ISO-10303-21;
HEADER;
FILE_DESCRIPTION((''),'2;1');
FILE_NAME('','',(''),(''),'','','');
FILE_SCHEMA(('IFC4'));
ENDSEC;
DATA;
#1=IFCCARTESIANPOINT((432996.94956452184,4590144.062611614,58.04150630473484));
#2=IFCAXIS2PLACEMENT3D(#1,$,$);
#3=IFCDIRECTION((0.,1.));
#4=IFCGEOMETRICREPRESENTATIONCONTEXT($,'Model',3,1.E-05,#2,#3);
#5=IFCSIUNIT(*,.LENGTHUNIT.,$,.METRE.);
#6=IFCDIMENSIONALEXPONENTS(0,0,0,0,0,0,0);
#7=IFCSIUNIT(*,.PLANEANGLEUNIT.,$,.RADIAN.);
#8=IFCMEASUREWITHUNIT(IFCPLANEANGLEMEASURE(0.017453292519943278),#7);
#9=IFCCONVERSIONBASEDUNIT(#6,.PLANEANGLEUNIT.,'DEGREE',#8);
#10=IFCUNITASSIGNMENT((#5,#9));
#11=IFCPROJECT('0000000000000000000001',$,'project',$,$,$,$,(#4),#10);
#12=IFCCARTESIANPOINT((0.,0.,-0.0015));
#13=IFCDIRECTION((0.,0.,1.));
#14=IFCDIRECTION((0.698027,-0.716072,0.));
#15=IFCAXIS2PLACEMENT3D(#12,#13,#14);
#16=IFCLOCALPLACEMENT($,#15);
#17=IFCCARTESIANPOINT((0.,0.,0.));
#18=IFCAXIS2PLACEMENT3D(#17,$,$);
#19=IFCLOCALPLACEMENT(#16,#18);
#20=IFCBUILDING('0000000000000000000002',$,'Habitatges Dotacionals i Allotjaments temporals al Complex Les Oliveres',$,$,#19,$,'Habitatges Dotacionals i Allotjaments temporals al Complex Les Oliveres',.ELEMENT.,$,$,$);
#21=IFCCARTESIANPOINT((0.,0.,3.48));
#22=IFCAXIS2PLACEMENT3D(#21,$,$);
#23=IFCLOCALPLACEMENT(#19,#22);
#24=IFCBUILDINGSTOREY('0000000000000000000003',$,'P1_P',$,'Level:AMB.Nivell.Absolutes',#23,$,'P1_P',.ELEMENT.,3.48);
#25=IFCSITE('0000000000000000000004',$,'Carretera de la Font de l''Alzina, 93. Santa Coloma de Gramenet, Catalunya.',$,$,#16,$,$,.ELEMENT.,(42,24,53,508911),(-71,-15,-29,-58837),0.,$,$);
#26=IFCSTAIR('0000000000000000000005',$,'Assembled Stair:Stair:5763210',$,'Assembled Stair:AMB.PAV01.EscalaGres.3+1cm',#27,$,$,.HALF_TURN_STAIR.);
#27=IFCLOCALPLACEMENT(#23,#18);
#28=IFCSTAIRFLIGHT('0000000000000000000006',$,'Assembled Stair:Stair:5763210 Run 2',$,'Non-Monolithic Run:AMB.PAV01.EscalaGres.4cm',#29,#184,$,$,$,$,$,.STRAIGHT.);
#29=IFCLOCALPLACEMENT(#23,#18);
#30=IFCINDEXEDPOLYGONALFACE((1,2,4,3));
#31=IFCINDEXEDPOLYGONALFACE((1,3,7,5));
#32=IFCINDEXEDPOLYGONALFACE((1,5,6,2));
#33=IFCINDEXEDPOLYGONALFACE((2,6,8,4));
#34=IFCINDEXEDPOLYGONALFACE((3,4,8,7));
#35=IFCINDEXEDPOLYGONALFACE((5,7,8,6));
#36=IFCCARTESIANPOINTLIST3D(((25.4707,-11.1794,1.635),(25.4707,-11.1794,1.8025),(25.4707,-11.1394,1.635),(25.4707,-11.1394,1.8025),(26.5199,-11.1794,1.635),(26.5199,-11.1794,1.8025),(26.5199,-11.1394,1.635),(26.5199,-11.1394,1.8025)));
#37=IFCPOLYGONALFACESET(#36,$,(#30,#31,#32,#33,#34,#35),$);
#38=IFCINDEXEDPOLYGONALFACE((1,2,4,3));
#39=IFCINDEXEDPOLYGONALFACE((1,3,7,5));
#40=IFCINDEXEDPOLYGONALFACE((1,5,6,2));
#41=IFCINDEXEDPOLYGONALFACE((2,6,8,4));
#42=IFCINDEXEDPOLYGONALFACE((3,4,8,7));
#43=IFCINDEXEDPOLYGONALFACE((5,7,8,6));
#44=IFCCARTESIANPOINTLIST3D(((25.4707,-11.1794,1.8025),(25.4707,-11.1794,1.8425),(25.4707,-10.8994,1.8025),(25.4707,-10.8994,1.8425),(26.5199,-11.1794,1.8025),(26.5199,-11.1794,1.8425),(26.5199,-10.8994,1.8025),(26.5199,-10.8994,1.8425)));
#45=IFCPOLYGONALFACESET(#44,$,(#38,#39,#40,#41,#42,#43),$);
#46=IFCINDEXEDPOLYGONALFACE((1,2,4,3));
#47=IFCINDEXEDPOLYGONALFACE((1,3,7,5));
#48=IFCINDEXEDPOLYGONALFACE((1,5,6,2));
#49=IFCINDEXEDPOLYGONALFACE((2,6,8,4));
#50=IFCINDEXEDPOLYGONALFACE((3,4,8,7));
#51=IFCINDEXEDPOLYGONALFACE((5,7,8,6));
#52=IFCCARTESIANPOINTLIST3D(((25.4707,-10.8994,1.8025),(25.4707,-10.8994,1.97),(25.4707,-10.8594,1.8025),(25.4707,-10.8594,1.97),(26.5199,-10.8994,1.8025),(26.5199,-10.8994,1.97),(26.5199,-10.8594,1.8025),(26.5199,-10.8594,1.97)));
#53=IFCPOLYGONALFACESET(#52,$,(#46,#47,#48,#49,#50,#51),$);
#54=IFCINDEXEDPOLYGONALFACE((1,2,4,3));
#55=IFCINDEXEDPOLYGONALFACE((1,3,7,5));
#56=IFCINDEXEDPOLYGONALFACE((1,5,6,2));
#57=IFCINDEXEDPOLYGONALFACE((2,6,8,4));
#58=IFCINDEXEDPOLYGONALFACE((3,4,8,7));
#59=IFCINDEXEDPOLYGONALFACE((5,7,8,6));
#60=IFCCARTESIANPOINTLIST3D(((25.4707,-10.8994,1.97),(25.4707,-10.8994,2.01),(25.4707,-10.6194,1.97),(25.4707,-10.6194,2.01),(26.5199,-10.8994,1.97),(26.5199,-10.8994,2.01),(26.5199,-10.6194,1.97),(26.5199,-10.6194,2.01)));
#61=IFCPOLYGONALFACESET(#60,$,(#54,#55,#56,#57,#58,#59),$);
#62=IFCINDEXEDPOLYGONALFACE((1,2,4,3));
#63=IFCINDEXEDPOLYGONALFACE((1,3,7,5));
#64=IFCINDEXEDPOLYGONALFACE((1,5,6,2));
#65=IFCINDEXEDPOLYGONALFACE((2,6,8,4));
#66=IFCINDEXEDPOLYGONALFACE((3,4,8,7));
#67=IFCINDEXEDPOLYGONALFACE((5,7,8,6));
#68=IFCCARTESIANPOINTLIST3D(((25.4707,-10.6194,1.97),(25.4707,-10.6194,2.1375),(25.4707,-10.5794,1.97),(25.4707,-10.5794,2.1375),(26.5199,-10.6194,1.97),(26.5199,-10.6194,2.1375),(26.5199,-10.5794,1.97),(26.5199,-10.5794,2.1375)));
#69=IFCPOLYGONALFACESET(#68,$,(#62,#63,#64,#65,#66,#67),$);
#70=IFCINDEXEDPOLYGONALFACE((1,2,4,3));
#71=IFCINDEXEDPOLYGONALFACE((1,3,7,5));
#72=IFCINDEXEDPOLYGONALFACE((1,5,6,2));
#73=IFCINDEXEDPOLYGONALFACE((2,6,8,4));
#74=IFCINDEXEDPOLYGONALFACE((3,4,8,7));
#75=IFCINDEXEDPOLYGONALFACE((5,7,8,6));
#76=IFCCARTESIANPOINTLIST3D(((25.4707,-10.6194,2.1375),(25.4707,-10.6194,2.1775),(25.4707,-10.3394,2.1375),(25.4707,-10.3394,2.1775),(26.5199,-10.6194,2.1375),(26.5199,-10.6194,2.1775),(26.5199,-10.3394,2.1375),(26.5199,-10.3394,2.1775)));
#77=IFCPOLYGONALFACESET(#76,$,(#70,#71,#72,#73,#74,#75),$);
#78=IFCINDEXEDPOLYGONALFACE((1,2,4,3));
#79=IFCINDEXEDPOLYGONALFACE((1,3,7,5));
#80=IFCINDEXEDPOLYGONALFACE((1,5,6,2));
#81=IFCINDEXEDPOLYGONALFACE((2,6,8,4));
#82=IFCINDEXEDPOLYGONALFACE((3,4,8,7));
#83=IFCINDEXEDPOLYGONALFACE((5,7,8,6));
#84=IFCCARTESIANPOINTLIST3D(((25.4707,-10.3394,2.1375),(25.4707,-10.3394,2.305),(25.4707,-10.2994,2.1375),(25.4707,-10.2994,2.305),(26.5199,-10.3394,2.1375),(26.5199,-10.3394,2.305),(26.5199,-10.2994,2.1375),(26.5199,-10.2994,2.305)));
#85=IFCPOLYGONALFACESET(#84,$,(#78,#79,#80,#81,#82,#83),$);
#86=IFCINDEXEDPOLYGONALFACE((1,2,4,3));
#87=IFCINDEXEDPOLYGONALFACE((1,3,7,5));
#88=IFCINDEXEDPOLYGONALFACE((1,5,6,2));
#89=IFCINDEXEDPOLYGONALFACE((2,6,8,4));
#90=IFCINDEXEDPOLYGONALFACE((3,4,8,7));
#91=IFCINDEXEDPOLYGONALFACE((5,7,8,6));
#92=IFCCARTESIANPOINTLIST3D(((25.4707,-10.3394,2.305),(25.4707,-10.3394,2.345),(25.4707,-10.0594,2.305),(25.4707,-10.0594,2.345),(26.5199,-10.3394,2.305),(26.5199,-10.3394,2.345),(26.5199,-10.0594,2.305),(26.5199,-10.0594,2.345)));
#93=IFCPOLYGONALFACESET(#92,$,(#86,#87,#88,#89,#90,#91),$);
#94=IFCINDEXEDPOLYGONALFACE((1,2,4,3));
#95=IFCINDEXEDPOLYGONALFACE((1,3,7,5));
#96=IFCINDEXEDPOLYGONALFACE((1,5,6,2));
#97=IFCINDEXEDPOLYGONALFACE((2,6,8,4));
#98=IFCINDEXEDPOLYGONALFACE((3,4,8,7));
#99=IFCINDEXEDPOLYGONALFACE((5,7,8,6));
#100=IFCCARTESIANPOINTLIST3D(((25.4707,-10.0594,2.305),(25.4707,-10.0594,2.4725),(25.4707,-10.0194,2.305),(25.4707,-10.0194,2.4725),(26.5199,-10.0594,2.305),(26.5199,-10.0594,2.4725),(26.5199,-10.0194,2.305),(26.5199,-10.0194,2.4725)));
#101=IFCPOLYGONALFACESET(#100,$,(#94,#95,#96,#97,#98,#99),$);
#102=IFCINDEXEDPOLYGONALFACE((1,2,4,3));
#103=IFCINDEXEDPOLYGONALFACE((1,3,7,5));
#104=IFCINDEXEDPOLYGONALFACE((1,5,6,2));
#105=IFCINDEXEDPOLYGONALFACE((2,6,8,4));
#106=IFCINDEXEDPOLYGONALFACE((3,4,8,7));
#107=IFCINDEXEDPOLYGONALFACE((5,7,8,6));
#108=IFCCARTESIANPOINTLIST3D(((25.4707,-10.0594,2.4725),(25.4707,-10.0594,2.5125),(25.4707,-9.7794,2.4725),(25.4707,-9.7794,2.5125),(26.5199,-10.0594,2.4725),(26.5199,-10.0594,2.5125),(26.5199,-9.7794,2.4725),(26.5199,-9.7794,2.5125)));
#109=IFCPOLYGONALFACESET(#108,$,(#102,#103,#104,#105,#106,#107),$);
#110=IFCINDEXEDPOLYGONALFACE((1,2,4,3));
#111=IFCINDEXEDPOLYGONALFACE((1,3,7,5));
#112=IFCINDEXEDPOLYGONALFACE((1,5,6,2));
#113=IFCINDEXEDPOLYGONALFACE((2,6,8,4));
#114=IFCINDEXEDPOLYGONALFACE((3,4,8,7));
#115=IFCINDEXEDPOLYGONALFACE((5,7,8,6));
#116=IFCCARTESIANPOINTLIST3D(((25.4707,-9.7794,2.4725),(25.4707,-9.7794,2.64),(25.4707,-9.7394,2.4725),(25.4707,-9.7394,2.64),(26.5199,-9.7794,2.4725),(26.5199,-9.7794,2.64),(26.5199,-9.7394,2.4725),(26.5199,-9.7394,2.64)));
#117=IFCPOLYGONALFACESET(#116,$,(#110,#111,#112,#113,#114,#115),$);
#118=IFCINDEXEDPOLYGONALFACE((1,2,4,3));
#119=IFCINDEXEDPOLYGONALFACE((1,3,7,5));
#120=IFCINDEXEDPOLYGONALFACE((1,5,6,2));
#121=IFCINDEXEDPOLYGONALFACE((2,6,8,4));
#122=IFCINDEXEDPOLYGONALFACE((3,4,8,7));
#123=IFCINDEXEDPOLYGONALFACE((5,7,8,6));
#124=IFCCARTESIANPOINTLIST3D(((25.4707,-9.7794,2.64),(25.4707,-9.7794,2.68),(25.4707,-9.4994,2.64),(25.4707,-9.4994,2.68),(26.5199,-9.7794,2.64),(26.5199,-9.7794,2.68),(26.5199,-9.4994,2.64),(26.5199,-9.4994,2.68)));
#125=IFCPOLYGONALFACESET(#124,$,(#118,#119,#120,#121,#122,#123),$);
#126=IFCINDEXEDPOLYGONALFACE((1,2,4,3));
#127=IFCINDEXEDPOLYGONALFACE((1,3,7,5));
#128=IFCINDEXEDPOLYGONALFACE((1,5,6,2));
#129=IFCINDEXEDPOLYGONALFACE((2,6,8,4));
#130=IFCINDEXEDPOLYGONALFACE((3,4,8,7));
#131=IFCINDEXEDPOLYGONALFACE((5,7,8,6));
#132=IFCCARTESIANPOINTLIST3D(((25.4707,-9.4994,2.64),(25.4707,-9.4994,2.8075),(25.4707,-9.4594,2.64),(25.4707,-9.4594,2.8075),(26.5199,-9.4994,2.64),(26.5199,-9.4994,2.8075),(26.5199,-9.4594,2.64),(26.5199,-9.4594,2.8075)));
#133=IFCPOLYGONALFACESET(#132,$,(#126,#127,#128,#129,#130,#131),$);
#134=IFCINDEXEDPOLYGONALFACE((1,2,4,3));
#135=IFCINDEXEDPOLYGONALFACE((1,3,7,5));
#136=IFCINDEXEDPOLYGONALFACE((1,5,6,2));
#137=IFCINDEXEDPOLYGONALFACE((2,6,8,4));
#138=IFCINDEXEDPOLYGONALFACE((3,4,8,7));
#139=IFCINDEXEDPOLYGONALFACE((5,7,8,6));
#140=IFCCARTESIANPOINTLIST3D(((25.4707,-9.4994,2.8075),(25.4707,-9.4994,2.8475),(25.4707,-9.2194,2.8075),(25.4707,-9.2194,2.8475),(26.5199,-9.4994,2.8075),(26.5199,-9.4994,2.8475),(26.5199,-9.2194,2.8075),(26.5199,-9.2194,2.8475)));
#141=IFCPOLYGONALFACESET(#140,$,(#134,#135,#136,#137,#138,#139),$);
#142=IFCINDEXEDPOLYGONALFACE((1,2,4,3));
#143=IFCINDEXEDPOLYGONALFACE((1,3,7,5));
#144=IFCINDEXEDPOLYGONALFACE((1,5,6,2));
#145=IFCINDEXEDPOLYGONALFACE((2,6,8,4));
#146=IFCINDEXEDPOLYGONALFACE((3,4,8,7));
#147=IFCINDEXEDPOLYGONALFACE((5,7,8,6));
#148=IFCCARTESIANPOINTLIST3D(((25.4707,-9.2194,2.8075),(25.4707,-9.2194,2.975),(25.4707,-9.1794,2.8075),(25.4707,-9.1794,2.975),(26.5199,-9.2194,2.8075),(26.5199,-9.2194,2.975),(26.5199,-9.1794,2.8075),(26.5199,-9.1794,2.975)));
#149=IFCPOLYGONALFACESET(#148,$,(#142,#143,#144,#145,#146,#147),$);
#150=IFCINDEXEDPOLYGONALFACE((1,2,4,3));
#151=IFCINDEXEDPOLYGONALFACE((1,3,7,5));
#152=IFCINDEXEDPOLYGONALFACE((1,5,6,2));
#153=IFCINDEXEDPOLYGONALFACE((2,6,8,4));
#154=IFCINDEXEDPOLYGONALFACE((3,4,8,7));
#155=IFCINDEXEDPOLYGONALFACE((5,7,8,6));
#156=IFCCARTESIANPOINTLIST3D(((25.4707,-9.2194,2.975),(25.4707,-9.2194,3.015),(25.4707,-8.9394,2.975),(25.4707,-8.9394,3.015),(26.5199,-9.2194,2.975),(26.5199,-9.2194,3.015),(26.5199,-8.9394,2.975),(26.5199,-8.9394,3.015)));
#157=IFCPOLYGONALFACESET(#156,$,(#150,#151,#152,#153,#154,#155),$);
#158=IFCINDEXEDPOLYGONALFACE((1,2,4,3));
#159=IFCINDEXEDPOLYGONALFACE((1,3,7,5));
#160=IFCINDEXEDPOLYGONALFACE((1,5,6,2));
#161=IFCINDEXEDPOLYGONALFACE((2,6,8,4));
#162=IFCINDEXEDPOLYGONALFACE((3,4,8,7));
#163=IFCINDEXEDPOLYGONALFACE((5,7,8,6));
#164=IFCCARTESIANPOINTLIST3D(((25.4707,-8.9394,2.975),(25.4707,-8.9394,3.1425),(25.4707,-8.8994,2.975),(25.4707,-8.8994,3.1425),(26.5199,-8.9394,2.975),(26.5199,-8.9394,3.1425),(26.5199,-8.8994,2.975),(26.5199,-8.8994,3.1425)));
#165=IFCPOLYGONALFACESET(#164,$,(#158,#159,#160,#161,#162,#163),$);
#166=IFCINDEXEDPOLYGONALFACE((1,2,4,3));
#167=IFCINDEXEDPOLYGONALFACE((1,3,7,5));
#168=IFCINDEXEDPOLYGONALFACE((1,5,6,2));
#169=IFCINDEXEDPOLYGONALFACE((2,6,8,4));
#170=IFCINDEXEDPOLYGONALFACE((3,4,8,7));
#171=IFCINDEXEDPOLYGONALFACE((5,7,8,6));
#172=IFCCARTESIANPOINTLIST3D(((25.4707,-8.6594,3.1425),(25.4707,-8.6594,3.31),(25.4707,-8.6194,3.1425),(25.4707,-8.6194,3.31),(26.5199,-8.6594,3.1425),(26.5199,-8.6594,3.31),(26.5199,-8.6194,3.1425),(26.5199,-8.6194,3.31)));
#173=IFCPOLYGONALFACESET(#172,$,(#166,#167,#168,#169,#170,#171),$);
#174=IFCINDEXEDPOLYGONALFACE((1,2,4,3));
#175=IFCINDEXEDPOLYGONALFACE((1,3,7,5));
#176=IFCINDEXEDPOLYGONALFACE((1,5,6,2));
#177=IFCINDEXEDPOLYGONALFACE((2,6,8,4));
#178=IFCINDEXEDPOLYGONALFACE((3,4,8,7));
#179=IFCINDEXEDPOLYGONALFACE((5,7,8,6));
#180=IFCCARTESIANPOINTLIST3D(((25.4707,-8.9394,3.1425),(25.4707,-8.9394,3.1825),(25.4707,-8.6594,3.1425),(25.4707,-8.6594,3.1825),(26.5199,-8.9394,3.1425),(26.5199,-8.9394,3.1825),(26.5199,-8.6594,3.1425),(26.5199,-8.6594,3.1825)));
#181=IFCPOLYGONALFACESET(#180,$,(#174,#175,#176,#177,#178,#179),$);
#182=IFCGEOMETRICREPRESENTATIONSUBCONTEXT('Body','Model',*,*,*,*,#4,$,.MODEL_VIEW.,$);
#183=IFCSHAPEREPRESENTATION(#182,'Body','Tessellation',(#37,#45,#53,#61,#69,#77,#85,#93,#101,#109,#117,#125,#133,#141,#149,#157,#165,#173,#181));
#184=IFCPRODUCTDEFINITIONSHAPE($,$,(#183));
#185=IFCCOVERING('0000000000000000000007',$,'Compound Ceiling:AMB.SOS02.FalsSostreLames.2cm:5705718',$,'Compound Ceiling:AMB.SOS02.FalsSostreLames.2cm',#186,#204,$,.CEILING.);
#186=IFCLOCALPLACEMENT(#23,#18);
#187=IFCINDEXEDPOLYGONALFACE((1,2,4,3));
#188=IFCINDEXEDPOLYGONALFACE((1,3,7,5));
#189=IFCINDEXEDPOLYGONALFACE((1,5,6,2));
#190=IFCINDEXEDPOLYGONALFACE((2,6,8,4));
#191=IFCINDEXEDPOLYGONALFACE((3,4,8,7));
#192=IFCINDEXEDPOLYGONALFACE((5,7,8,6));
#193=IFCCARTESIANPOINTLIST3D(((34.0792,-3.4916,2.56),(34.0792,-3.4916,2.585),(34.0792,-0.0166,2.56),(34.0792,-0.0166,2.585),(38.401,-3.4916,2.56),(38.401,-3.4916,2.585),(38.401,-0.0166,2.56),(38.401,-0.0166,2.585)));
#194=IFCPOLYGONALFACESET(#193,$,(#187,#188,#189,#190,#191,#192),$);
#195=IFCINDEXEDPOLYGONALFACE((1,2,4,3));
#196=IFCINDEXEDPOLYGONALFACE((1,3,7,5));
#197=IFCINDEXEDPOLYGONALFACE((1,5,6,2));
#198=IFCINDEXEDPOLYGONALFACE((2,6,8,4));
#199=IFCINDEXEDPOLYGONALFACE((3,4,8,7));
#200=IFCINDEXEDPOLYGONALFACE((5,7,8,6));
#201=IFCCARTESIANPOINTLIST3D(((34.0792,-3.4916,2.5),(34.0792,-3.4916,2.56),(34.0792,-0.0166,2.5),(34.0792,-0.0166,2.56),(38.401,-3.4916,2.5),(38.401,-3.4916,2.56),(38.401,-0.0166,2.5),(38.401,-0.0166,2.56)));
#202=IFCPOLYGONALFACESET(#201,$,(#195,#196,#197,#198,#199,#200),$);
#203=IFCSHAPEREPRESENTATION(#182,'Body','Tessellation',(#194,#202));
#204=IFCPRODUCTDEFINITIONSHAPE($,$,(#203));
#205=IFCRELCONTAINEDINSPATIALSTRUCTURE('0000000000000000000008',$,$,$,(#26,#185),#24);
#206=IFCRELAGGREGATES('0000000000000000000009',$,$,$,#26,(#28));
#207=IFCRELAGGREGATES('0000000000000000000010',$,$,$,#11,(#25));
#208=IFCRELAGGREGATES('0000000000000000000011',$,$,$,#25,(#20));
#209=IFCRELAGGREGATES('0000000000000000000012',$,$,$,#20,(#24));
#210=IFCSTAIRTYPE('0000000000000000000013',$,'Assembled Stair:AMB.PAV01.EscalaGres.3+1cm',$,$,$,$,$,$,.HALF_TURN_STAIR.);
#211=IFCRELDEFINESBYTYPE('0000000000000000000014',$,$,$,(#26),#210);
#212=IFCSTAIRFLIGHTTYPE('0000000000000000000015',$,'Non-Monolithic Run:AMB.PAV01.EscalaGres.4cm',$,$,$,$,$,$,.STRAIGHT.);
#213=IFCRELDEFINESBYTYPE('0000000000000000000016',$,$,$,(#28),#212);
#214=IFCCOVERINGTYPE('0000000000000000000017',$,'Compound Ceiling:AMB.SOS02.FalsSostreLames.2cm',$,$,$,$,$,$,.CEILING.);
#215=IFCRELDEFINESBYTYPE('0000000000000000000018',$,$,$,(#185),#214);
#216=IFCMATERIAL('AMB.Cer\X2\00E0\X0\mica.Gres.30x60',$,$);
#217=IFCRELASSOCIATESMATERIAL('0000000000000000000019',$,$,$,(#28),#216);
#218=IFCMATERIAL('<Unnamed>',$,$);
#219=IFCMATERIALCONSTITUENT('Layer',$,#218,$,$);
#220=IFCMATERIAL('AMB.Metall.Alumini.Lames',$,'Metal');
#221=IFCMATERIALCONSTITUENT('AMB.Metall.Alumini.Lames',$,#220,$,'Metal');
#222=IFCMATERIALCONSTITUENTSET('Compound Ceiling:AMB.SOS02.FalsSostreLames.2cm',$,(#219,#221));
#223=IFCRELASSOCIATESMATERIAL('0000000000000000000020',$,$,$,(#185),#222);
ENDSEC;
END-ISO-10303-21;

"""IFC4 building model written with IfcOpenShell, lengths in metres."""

from ifc_helpers import new_model, entity, si_unit, converted_unit, direction, frame, origin, place, context, subcontext, project, spatial, indexed_curve, outline, extrude, material, constituent, constituent_set, type_object, element, aggregate, save


model = new_model("IFC4")

# Units and contexts
model_context = context("Model", 3, precision=1e-05, world=frame((432996.94956452184, 4590144.062611614, 58.04150630473484)), true_north=direction((0.0, 1.0)))
body_context = subcontext(model_context, "Body", "Model", "MODEL_VIEW")
ifc_project = project(units=[si_unit("LENGTHUNIT", "METRE"), converted_unit("PLANEANGLEUNIT", "DEGREE", entity("IfcPlaneAngleMeasure", 0.017453292519943278), si_unit("PLANEANGLEUNIT", "RADIAN"), dimensions=[0, 0, 0, 0, 0, 0, 0])], contexts=[model_context])

# Site, building, storey
site_placement = place(None, frame((0.0, 0.0, -0.0015), z_axis=(0.0, 0.0, 1.0), x_axis=(0.698027, -0.716072, 0.0)))
site = spatial("IfcSite", under=ifc_project, at=site_placement, Name="Carretera de la Font de l'Alzina, 93. Santa Coloma de Gramenet, Catalunya.", CompositionType="ELEMENT", RefLatitude=(42, 24, 53, 508911), RefLongitude=(-71, -15, -29, -58837), RefElevation=0.0)
building_placement = place(site_placement, origin())
building = spatial("IfcBuilding", under=site, at=building_placement, Name="Habitatges Dotacionals i Allotjaments temporals al Complex Les Oliveres", LongName="Habitatges Dotacionals i Allotjaments temporals al Complex Les Oliveres", CompositionType="ELEMENT")
storey_placement = place(building_placement, frame((0.0, 0.0, 3.48)))
storey = spatial("IfcBuildingStorey", under=building, at=storey_placement, Name="P1_P", ObjectType="Level:AMB.Nivell.Absolutes", LongName="P1_P", CompositionType="ELEMENT", Elevation=3.48)

# Shared definitions
ifc_material_1 = material(Name="<Unnamed>")

# Stair
stair_type_1 = type_object("IfcStairType", Name="Assembled Stair:AMB.PAV01.EscalaGres.3+1cm", PredefinedType="HALF_TURN_STAIR")
ifc_material_2 = material(Name="AMB.Ceràmica.Gres.30x60")
stair_1_placement = place(storey_placement, origin())
stair_1 = element("IfcStair", 1, at=stair_1_placement, inside=storey, type_object=stair_type_1, Name="Assembled Stair:Stair:5763210", ObjectType="Assembled Stair:AMB.PAV01.EscalaGres.3+1cm", PredefinedType="HALF_TURN_STAIR")

# Shared definitions
stair_flight_type = type_object("IfcStairFlightType", Name="Non-Monolithic Run:AMB.PAV01.EscalaGres.4cm", PredefinedType="STRAIGHT")

# Stair flight
stair_flight_1_placement = place(stair_1_placement, origin())
stair_flight_1 = element("IfcStairFlight", 2, at=stair_flight_1_placement, type_object=stair_flight_type, material=ifc_material_2, Name="Assembled Stair:Stair:5763210 Run 2", ObjectType="Non-Monolithic Run:AMB.PAV01.EscalaGres.4cm", PredefinedType="STRAIGHT", context=body_context, shape_type="SweptSolid", body=[
    extrude(outline(indexed_curve([(-0.5246, -0.02), (0.5246, -0.02), (0.5246, 0.02), (-0.5246, 0.02), (-0.5246, -0.02)], self_intersect=False)), frame((25.9953, -11.1594, 1.635), z_axis=(0.0, 0.0, 1.0), x_axis=(-1.0, 0.0, 0.0)), (0.0, 0.0, 1.0), 0.1675),
    extrude(outline(indexed_curve([(-0.14, -0.5246), (0.14, -0.5246), (0.14, 0.5246), (-0.14, 0.5246), (-0.14, -0.5246)], self_intersect=False)), frame((25.9953, -11.0394, 1.8025), z_axis=(0.0, 0.0, 1.0), x_axis=(0.0, -1.0, 0.0)), (0.0, 0.0, 1.0), 0.04),
    extrude(outline(indexed_curve([(-0.5246, -0.02), (0.5246, -0.02), (0.5246, 0.02), (-0.5246, 0.02), (-0.5246, -0.02)], self_intersect=False)), frame((25.9953, -10.8794, 1.8025), z_axis=(0.0, 0.0, 1.0), x_axis=(-1.0, 0.0, 0.0)), (0.0, 0.0, 1.0), 0.1675),
    extrude(outline(indexed_curve([(-0.14, -0.5246), (0.14, -0.5246), (0.14, 0.5246), (-0.14, 0.5246), (-0.14, -0.5246)], self_intersect=False)), frame((25.9953, -10.7594, 1.97), z_axis=(0.0, 0.0, 1.0), x_axis=(0.0, -1.0, 0.0)), (0.0, 0.0, 1.0), 0.04),
    extrude(outline(indexed_curve([(-0.5246, -0.02), (0.5246, -0.02), (0.5246, 0.02), (-0.5246, 0.02), (-0.5246, -0.02)], self_intersect=False)), frame((25.9953, -10.5994, 1.97), z_axis=(0.0, 0.0, 1.0), x_axis=(-1.0, 0.0, 0.0)), (0.0, 0.0, 1.0), 0.1675),
    extrude(outline(indexed_curve([(-0.14, -0.5246), (0.14, -0.5246), (0.14, 0.5246), (-0.14, 0.5246), (-0.14, -0.5246)], self_intersect=False)), frame((25.9953, -10.4794, 2.1375), z_axis=(0.0, 0.0, 1.0), x_axis=(0.0, -1.0, 0.0)), (0.0, 0.0, 1.0), 0.04),
    extrude(outline(indexed_curve([(-0.5246, -0.02), (0.5246, -0.02), (0.5246, 0.02), (-0.5246, 0.02), (-0.5246, -0.02)], self_intersect=False)), frame((25.9953, -10.3194, 2.1375), z_axis=(0.0, 0.0, 1.0), x_axis=(-1.0, 0.0, 0.0)), (0.0, 0.0, 1.0), 0.1675),
    extrude(outline(indexed_curve([(-0.14, -0.5246), (0.14, -0.5246), (0.14, 0.5246), (-0.14, 0.5246), (-0.14, -0.5246)], self_intersect=False)), frame((25.9953, -10.1994, 2.305), z_axis=(0.0, 0.0, 1.0), x_axis=(0.0, -1.0, 0.0)), (0.0, 0.0, 1.0), 0.04),
    extrude(outline(indexed_curve([(-0.5246, -0.02), (0.5246, -0.02), (0.5246, 0.02), (-0.5246, 0.02), (-0.5246, -0.02)], self_intersect=False)), frame((25.9953, -10.0394, 2.305), z_axis=(0.0, 0.0, 1.0), x_axis=(-1.0, 0.0, 0.0)), (0.0, 0.0, 1.0), 0.1675),
    extrude(outline(indexed_curve([(-0.14, -0.5246), (0.14, -0.5246), (0.14, 0.5246), (-0.14, 0.5246), (-0.14, -0.5246)], self_intersect=False)), frame((25.9953, -9.9194, 2.4725), z_axis=(0.0, 0.0, 1.0), x_axis=(0.0, -1.0, 0.0)), (0.0, 0.0, 1.0), 0.04),
    extrude(outline(indexed_curve([(-0.5246, -0.02), (0.5246, -0.02), (0.5246, 0.02), (-0.5246, 0.02), (-0.5246, -0.02)], self_intersect=False)), frame((25.9953, -9.7594, 2.4725), z_axis=(0.0, 0.0, 1.0), x_axis=(-1.0, 0.0, 0.0)), (0.0, 0.0, 1.0), 0.1675),
    extrude(outline(indexed_curve([(-0.14, -0.5246), (0.14, -0.5246), (0.14, 0.5246), (-0.14, 0.5246), (-0.14, -0.5246)], self_intersect=False)), frame((25.9953, -9.6394, 2.64), z_axis=(0.0, 0.0, 1.0), x_axis=(0.0, -1.0, 0.0)), (0.0, 0.0, 1.0), 0.04),
    extrude(outline(indexed_curve([(-0.5246, -0.02), (0.5246, -0.02), (0.5246, 0.02), (-0.5246, 0.02), (-0.5246, -0.02)], self_intersect=False)), frame((25.9953, -9.4794, 2.64), z_axis=(0.0, 0.0, 1.0), x_axis=(-1.0, 0.0, 0.0)), (0.0, 0.0, 1.0), 0.1675),
    extrude(outline(indexed_curve([(-0.14, -0.5246), (0.14, -0.5246), (0.14, 0.5246), (-0.14, 0.5246), (-0.14, -0.5246)], self_intersect=False)), frame((25.9953, -9.3594, 2.8075), z_axis=(0.0, 0.0, 1.0), x_axis=(0.0, -1.0, 0.0)), (0.0, 0.0, 1.0), 0.04),
    extrude(outline(indexed_curve([(-0.5246, -0.02), (0.5246, -0.02), (0.5246, 0.02), (-0.5246, 0.02), (-0.5246, -0.02)], self_intersect=False)), frame((25.9953, -9.1994, 2.8075), z_axis=(0.0, 0.0, 1.0), x_axis=(-1.0, 0.0, 0.0)), (0.0, 0.0, 1.0), 0.1675),
    extrude(outline(indexed_curve([(-0.14, -0.5246), (0.14, -0.5246), (0.14, 0.5246), (-0.14, 0.5246), (-0.14, -0.5246)], self_intersect=False)), frame((25.9953, -9.0794, 2.975), z_axis=(0.0, 0.0, 1.0), x_axis=(0.0, -1.0, 0.0)), (0.0, 0.0, 1.0), 0.04),
    extrude(outline(indexed_curve([(-0.5246, -0.02), (0.5246, -0.02), (0.5246, 0.02), (-0.5246, 0.02), (-0.5246, -0.02)], self_intersect=False)), frame((25.9953, -8.9194, 2.975), z_axis=(0.0, 0.0, 1.0), x_axis=(-1.0, 0.0, 0.0)), (0.0, 0.0, 1.0), 0.1675),
    extrude(outline(indexed_curve([(-0.5246, -0.02), (0.5246, -0.02), (0.5246, 0.02), (-0.5246, 0.02), (-0.5246, -0.02)], self_intersect=False)), frame((25.9953, -8.6394, 3.1425), z_axis=(0.0, 0.0, 1.0), x_axis=(-1.0, 0.0, 0.0)), (0.0, 0.0, 1.0), 0.1675),
    extrude(outline(indexed_curve([(-0.14, -0.5246), (0.14, -0.5246), (0.14, 0.5246), (-0.14, 0.5246), (-0.14, -0.5246)], self_intersect=False)), frame((25.9953, -8.7994, 3.1425), z_axis=(0.0, 0.0, 1.0), x_axis=(0.0, -1.0, 0.0)), (0.0, 0.0, 1.0), 0.04),
])
aggregate(stair_1, [stair_flight_1])

# Covering
ifc_constituent_1 = constituent(ifc_material_1, Name="Layer")
ifc_material_3 = material(Name="AMB.Metall.Alumini.Lames", Category="Metal")
ifc_constituent_2 = constituent(ifc_material_3, Name="AMB.Metall.Alumini.Lames", Category="Metal")
ifc_constituent_set_1 = constituent_set(constituents=[ifc_constituent_1, ifc_constituent_2], Name="Compound Ceiling:AMB.SOS02.FalsSostreLames.2cm")
covering_type_1 = type_object("IfcCoveringType", Name="Compound Ceiling:AMB.SOS02.FalsSostreLames.2cm", PredefinedType="CEILING")
covering_1_placement = place(storey_placement, origin())
element("IfcCovering", 3, at=covering_1_placement, inside=storey, type_object=covering_type_1, material=ifc_constituent_set_1, Name="Compound Ceiling:AMB.SOS02.FalsSostreLames.2cm:5705718", ObjectType="Compound Ceiling:AMB.SOS02.FalsSostreLames.2cm", PredefinedType="CEILING", context=body_context, shape_type="SweptSolid", body=[
    extrude(outline(indexed_curve([(-2.1609, -1.7375), (2.1609, -1.7375), (2.1609, 1.7375), (-2.1609, 1.7375), (-2.1609, -1.7375)], self_intersect=False)), frame((36.2401, -1.7541, 2.56)), (0.0, 0.0, 1.0), 0.025),
    extrude(outline(indexed_curve([(-1.7375, -2.1609), (1.7375, -2.1609), (1.7375, 2.1609), (-1.7375, 2.1609), (-1.7375, -2.1609)], self_intersect=False)), frame((36.2401, -1.7541, 2.5), z_axis=(0.0, 0.0, 1.0), x_axis=(0.0, -1.0, 0.0)), (0.0, 0.0, 1.0), 0.06),
])

save(model, "model.ifc")
